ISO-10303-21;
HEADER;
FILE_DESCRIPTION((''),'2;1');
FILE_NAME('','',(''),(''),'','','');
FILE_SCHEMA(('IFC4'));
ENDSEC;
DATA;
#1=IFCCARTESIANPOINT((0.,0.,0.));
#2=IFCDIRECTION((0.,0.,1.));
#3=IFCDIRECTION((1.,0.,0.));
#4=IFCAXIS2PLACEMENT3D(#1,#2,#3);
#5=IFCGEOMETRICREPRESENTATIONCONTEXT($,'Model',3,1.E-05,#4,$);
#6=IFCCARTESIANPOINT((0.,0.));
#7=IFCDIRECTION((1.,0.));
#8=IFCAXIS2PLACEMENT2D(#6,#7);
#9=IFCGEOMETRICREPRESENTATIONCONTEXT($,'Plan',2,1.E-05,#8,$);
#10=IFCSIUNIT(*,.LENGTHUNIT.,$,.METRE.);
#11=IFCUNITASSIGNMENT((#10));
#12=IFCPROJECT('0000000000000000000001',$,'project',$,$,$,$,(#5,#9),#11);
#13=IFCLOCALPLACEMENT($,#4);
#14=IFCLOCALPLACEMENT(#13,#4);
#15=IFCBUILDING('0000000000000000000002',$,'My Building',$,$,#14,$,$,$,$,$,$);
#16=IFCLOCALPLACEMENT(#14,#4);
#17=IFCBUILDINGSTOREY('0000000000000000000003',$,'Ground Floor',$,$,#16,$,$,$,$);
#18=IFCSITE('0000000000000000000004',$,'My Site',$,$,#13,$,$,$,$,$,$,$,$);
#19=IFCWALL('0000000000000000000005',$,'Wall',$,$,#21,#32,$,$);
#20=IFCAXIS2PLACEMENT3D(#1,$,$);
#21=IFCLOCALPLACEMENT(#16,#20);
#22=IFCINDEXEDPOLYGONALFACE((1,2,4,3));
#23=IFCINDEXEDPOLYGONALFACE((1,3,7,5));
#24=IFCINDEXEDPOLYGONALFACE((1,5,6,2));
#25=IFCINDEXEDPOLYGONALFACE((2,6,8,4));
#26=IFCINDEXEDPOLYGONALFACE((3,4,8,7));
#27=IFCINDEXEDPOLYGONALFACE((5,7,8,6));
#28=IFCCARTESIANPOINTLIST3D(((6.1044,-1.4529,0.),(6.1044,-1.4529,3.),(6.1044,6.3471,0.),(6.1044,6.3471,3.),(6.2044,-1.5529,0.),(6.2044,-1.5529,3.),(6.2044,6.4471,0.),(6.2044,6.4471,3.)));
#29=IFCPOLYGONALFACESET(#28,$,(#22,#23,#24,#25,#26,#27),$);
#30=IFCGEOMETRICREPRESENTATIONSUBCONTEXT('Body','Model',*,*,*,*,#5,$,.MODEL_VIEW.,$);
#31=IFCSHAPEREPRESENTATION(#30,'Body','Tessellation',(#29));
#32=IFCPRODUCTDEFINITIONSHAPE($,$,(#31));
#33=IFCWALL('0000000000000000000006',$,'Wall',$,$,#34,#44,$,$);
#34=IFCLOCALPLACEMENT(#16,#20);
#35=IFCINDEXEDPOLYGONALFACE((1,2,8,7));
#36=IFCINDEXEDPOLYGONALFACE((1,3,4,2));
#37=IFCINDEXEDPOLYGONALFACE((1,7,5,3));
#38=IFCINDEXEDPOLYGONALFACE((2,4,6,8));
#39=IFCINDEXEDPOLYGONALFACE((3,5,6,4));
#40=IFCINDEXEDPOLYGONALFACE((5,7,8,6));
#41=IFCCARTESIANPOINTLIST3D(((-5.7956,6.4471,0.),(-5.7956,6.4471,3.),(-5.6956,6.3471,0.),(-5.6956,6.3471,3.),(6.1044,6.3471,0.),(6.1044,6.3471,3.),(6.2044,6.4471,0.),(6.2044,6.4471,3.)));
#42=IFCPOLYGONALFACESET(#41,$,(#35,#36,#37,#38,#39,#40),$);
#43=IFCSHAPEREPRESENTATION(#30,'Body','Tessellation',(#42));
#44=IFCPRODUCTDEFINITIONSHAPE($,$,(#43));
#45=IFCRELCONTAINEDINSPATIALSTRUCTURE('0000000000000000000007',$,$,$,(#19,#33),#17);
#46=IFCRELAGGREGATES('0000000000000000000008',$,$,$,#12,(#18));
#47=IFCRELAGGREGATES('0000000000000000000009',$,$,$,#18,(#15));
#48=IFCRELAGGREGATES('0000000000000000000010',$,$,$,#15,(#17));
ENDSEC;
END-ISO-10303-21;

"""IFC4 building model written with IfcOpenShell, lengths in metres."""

from ifc_helpers import new_model, si_unit, frame, origin_with_axes, origin_2d_with_axis, place, context, subcontext, project, spatial, line, indexed_curve, outline, extrude, element, save


model = new_model("IFC4")

# Units and contexts
model_context = context("Model", 3, precision=1e-05, world=origin_with_axes())
plan_context = context("Plan", 2, precision=1e-05, world=origin_2d_with_axis())
body_context_1 = subcontext(model_context, "Body", "Model", "MODEL_VIEW")
ifc_project = project(units=[si_unit("LENGTHUNIT", "METRE")], contexts=[model_context, plan_context])

# Site, building, storey
site_placement = place(None, origin_with_axes())
site = spatial("IfcSite", under=ifc_project, at=site_placement, Name="My Site")
building_placement = place(site_placement, origin_with_axes())
building = spatial("IfcBuilding", under=site, at=building_placement, Name="My Building")
storey_placement = place(building_placement, origin_with_axes())
storey = spatial("IfcBuildingStorey", under=building, at=storey_placement, Name="Ground Floor")

# Walls
wall_1_placement = place(storey_placement, frame((6.2044, -1.5529, 0.0), z_axis=(0.0, 0.0, 1.0), x_axis=(0.0, 1.0, 0.0)))
element("IfcWall", 1, at=wall_1_placement, inside=storey, Name="Wall", context=body_context_1, shape_type="SweptSolid", body=[
    extrude(outline(indexed_curve([(0.0, 0.0), (0.1, 0.1), (7.9, 0.1), (8.0, 0.0)], segments=[line(1, 2, 3, 4, 1)])), origin_with_axes(), (0.0, 0.0, 1.0), 3.0),
])
wall_2_placement = place(storey_placement, frame((6.2044, 6.4471, 0.0), z_axis=(0.0, 0.0, 1.0), x_axis=(-1.0, 0.0, 0.0)))
element("IfcWall", 2, at=wall_2_placement, inside=storey, Name="Wall", context=body_context_1, shape_type="SweptSolid", body=[
    extrude(outline(indexed_curve([(0.0, 0.0), (0.1, 0.1), (11.9, 0.1), (12.0, 0.0)], segments=[line(1, 2, 3, 4, 1)])), origin_with_axes(), (0.0, 0.0, 1.0), 3.0),
])

save(model, "model.ifc")
